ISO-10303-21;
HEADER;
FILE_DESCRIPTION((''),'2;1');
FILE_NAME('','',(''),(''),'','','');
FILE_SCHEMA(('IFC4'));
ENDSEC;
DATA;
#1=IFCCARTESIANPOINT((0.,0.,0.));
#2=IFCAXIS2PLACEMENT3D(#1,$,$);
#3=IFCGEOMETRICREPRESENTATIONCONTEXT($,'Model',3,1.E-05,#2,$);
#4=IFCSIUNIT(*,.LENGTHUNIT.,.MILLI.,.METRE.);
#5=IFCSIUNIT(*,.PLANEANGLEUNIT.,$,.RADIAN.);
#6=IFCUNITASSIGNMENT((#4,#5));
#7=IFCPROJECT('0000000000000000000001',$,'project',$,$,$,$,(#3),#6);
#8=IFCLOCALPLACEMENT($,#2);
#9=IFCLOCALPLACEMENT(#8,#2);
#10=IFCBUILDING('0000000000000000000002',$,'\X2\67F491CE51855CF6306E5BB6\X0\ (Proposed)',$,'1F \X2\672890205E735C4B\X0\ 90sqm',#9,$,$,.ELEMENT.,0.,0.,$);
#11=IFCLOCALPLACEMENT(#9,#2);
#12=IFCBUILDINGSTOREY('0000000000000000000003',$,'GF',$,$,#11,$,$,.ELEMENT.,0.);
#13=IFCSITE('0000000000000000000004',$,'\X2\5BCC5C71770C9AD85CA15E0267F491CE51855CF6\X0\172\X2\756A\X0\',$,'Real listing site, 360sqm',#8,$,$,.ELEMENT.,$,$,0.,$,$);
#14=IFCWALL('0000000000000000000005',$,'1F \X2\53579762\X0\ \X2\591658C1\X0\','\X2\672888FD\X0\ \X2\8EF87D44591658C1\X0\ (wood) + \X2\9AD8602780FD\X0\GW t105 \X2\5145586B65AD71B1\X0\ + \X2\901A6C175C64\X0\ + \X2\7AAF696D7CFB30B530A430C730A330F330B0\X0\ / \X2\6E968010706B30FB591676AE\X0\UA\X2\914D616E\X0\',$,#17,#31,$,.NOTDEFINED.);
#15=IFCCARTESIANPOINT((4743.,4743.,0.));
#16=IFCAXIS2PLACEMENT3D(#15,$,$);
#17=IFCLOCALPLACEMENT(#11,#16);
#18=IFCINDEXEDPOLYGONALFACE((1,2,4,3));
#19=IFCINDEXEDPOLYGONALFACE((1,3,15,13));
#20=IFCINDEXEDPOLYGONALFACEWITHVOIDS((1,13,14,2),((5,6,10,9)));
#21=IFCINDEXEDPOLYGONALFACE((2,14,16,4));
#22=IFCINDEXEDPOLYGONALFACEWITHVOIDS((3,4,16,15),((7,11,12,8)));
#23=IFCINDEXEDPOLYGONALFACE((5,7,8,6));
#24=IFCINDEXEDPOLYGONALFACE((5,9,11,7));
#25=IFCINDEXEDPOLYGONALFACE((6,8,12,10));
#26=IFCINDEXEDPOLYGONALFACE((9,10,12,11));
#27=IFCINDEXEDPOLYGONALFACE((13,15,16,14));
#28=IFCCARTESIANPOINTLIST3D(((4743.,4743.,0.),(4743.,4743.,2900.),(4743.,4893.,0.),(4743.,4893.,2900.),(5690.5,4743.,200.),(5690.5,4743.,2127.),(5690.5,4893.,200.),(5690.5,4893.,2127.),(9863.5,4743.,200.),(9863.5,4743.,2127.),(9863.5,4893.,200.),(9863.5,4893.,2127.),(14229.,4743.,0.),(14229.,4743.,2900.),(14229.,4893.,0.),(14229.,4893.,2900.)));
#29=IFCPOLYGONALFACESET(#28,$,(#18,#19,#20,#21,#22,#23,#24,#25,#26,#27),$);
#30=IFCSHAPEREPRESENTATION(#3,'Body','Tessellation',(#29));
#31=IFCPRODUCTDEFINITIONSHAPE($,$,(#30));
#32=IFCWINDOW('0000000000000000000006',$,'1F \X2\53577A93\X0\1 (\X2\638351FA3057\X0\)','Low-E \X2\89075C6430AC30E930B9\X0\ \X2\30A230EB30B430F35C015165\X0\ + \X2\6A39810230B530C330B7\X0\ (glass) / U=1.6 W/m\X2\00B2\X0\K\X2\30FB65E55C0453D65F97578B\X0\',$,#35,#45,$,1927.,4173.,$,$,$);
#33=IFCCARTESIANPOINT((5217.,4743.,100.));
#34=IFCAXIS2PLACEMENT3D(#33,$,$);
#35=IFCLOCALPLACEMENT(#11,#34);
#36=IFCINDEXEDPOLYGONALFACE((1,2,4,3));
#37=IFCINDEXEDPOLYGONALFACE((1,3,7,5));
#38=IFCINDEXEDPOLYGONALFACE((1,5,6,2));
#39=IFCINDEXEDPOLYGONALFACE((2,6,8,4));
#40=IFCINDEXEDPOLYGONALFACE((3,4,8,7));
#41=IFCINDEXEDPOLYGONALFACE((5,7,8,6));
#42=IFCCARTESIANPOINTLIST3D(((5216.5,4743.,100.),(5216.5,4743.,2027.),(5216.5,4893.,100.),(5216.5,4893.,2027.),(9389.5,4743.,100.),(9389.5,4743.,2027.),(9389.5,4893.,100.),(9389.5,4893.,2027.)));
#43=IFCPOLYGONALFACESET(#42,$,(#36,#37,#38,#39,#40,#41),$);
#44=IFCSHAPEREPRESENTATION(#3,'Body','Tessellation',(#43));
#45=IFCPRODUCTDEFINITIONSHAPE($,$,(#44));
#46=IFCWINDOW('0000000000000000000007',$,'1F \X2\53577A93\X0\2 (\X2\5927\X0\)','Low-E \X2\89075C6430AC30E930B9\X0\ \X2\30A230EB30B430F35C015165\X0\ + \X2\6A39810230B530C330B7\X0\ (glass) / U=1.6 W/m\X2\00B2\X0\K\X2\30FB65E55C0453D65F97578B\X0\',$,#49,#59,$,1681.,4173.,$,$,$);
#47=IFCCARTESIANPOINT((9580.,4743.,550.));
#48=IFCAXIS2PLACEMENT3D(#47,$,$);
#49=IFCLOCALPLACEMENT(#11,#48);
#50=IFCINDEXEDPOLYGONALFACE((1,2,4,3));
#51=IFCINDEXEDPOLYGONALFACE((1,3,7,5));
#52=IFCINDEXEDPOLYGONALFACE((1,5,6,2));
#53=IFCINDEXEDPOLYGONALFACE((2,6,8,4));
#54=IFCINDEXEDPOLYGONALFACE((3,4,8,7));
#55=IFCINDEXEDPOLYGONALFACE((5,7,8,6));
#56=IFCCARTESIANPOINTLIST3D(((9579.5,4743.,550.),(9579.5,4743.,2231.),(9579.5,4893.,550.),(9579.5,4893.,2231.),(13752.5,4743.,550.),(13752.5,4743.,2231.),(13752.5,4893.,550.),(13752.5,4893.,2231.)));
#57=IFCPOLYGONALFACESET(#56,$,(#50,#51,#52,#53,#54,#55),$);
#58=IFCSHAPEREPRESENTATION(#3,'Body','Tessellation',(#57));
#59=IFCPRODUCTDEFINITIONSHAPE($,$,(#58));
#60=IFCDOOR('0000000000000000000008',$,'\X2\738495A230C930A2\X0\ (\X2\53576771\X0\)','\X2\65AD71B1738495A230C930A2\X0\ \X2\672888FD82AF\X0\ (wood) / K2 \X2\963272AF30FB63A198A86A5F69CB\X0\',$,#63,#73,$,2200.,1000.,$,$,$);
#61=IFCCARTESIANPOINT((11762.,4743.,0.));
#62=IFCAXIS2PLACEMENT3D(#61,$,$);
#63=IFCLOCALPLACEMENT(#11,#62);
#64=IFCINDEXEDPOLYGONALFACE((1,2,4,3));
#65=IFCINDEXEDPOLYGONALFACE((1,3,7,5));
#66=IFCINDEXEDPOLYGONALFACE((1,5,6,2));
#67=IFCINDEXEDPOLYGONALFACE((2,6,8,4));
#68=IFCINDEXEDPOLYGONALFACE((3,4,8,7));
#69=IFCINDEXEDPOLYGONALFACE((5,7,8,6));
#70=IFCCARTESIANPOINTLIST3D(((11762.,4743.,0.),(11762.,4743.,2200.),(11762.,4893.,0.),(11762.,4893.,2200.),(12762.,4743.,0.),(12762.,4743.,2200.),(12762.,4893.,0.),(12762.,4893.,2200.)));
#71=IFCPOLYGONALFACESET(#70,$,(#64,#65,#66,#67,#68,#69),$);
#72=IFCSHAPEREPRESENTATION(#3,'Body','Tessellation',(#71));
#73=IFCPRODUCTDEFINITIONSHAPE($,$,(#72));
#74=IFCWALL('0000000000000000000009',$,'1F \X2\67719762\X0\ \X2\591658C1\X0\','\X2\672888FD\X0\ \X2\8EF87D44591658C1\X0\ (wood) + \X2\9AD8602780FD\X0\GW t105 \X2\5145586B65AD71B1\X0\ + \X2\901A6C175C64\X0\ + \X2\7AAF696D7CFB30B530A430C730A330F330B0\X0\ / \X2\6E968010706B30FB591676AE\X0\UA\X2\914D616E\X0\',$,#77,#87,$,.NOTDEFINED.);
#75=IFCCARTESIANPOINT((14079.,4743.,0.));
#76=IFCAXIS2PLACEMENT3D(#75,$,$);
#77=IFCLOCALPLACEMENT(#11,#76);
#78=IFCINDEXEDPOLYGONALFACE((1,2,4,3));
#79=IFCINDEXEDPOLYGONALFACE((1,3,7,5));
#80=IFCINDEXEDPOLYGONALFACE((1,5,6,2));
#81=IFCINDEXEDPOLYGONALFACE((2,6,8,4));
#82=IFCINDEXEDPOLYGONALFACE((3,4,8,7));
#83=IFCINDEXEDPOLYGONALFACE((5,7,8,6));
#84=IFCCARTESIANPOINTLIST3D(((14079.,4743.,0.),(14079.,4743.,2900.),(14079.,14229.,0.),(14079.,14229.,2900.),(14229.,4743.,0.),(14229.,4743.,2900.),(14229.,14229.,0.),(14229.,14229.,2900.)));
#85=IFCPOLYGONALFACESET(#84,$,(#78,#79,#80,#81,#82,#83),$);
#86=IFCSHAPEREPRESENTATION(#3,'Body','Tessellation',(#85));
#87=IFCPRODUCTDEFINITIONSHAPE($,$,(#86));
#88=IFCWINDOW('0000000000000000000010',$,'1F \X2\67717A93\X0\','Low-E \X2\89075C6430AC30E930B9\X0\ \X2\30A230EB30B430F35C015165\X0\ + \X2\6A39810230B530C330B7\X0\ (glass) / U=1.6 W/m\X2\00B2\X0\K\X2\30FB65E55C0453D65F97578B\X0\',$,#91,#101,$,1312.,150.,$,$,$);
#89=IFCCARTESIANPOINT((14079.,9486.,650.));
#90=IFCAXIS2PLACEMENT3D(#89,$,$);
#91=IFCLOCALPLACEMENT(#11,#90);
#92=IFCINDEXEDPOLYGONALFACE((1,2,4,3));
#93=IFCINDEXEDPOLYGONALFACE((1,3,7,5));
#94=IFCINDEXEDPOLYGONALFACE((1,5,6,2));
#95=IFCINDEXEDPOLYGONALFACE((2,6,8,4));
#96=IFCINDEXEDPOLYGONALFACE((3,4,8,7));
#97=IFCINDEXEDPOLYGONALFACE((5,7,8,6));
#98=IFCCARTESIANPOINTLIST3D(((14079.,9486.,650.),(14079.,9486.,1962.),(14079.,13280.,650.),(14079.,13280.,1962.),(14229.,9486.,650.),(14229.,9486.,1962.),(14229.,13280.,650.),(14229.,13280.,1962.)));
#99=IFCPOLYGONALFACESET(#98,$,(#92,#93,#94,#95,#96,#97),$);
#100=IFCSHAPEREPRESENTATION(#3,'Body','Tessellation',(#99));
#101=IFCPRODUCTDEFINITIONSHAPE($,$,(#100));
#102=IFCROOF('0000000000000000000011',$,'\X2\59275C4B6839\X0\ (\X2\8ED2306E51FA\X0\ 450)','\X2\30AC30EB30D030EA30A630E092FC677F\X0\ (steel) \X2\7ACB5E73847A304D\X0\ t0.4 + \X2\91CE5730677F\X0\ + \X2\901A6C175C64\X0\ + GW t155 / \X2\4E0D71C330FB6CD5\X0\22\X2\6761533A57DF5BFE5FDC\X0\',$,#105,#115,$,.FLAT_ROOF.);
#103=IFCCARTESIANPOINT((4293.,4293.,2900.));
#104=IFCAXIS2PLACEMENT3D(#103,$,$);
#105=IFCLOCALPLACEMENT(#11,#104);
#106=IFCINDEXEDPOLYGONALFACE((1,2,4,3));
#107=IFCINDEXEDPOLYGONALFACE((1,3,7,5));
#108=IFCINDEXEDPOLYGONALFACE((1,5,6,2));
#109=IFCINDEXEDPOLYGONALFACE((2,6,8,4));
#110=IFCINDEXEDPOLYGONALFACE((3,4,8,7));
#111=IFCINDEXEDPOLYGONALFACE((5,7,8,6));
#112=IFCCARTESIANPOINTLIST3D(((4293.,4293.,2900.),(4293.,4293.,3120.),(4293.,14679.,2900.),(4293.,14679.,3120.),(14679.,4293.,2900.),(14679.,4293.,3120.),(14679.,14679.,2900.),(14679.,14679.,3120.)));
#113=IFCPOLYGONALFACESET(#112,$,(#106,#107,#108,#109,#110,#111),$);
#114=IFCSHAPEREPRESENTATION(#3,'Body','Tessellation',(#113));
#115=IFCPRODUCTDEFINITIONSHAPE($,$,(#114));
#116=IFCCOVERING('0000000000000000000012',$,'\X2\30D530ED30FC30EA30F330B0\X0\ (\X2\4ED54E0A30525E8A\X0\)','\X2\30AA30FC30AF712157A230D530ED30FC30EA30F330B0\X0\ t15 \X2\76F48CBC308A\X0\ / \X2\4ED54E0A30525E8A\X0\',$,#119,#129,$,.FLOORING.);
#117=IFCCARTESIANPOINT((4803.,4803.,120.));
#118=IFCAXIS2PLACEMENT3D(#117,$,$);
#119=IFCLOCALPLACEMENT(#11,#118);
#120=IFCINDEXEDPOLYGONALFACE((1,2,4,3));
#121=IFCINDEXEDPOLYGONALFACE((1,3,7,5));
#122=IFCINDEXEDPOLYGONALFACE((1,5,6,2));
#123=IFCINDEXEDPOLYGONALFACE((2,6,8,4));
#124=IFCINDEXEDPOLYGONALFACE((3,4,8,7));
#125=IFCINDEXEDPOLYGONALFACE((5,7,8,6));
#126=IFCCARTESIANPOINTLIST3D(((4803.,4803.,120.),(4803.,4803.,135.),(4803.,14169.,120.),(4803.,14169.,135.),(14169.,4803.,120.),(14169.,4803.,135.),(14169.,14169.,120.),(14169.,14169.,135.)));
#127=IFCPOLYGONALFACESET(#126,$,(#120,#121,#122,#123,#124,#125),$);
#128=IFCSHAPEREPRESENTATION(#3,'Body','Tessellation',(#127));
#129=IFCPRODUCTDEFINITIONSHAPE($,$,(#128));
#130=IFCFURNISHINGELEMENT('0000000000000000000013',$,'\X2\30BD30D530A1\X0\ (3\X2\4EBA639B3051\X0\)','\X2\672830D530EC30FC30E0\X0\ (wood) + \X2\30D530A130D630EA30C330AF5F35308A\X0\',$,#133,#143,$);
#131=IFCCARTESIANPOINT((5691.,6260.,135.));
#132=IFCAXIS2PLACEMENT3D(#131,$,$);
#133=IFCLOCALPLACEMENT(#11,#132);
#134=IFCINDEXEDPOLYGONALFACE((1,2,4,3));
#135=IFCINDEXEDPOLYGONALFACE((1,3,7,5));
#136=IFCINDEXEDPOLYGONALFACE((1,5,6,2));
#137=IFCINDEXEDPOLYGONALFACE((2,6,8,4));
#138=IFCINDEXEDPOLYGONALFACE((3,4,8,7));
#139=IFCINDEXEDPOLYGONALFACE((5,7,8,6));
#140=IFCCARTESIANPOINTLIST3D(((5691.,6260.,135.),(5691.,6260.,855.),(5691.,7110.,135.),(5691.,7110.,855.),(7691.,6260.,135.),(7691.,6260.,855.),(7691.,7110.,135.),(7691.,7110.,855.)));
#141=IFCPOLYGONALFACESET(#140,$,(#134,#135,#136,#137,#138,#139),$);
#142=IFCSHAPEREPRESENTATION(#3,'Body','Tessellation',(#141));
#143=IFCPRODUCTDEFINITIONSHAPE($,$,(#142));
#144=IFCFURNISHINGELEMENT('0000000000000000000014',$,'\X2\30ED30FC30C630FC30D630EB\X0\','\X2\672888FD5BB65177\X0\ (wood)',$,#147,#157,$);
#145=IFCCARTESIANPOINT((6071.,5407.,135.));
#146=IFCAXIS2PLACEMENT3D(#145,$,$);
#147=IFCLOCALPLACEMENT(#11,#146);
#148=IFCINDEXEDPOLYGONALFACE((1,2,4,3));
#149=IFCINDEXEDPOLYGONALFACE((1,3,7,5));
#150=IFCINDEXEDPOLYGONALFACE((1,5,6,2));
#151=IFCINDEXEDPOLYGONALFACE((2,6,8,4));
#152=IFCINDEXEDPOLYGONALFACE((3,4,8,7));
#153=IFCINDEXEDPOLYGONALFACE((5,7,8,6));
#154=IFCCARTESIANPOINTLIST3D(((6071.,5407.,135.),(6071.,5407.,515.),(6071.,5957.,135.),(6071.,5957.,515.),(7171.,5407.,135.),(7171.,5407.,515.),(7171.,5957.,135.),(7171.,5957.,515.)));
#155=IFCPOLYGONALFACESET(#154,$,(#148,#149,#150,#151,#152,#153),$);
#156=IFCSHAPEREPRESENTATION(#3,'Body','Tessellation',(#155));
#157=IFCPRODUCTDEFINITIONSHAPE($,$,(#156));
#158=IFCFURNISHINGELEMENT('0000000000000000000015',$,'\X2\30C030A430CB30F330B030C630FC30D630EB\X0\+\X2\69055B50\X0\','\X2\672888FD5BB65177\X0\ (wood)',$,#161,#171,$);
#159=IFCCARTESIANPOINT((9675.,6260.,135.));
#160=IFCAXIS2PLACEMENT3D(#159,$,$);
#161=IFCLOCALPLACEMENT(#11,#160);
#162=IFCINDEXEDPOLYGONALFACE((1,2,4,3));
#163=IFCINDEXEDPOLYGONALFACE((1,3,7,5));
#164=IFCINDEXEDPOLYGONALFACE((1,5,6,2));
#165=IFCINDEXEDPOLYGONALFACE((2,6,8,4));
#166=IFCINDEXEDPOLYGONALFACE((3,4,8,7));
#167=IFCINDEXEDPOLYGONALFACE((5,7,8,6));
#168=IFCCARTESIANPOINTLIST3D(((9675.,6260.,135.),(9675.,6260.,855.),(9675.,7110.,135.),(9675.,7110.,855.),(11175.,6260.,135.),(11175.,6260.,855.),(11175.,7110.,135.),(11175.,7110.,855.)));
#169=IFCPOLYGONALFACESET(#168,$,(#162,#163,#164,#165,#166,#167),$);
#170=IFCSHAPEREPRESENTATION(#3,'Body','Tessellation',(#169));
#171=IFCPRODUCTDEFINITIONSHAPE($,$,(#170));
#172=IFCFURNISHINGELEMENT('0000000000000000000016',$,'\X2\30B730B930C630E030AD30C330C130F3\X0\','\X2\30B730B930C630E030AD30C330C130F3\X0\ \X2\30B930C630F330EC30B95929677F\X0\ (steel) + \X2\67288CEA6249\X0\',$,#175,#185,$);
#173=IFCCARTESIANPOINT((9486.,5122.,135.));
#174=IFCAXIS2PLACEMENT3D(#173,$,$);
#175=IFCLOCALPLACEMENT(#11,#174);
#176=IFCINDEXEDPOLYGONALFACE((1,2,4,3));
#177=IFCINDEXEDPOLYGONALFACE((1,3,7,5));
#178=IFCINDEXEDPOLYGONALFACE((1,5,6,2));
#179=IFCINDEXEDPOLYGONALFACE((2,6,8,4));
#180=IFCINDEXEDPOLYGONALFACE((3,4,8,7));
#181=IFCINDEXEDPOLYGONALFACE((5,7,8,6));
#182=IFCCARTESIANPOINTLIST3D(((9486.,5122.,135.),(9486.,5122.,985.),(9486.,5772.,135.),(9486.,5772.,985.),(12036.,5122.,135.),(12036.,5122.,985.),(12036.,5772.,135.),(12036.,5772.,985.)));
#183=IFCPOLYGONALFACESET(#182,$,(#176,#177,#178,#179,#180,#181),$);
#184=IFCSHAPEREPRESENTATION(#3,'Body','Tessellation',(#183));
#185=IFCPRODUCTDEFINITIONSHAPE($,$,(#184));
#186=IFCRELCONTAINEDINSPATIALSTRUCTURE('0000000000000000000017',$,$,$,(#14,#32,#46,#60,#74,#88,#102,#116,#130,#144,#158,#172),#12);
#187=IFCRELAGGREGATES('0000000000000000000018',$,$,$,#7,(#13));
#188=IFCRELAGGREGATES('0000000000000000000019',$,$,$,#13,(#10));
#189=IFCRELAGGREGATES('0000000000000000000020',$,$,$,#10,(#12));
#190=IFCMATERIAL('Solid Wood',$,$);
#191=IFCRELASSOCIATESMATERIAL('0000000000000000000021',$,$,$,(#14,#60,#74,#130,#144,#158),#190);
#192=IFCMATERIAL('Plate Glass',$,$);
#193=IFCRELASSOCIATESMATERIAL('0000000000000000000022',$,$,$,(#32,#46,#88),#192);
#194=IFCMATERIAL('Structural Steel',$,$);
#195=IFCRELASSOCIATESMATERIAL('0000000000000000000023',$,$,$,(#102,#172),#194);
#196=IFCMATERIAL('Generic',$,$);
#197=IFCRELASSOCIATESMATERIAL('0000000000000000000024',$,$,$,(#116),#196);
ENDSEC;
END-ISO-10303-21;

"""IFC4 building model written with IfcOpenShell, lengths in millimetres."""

from ifc_helpers import new_model, si_unit, frame, frame_2d, origin, place, context, project, spatial, rectangle, extrude, material, element, fill, save


model = new_model("IFC4")

# Units and contexts
model_context = context("Model", 3, precision=1e-05, world=origin())
ifc_project = project(units=[si_unit("LENGTHUNIT", "METRE", prefix="MILLI"), si_unit("PLANEANGLEUNIT", "RADIAN")], contexts=[model_context])

# Site, building, storey
site_placement = place(None, origin())
site = spatial("IfcSite", under=ifc_project, at=site_placement, Name="富山県高岡市柴野内島172番", ObjectType="Real listing site, 360sqm", CompositionType="ELEMENT", RefElevation=0.0)
building_placement = place(site_placement, origin())
building = spatial("IfcBuilding", under=site, at=building_placement, Name="柴野内島の家 (Proposed)", ObjectType="1F 木造平屋 90sqm", CompositionType="ELEMENT", ElevationOfRefHeight=0.0, ElevationOfTerrain=0.0)
storey_placement = place(building_placement, origin())
storey = spatial("IfcBuildingStorey", under=building, at=storey_placement, Name="GF", CompositionType="ELEMENT", Elevation=0.0)

# Shared definitions
ifc_material_1 = material(Name="Solid Wood")

# Wall, openings, windows, door
wall_1_placement = place(storey_placement, frame((4743.0, 4743.0, 0.0)))
wall_1 = element("IfcWall", 1, at=wall_1_placement, inside=storey, material=ifc_material_1, Name="1F 南面 外壁", Description="木製 軸組外壁 (wood) + 高性能GW t105 充填断熱 + 通気層 + 窯業系サイディング / 準耐火・外皮UA配慮", PredefinedType="NOTDEFINED", context=model_context, shape_type="SweptSolid", body=[
    extrude(rectangle(XDim=9486.0, YDim=150.0, at=frame_2d((4743.0, 75.0))), frame((4743.0, 4743.0, 0.0)), (0.0, 0.0, 1.0), 2900.0),
])
opening_1_placement = place(storey_placement, frame((5217.0, 4743.0, 100.0)))
opening_1 = element("IfcOpeningElement", 2, at=opening_1_placement, cuts=wall_1, PredefinedType="NOTDEFINED", context=model_context, shape_type="SweptSolid", body=[
    extrude(rectangle(XDim=4173.0, YDim=150.0, at=frame_2d((2086.0, 75.0))), frame((5217.0, 4743.0, 100.0)), (0.0, 0.0, 1.0), 1927.0),
])
opening_2_placement = place(storey_placement, frame((9580.0, 4743.0, 550.0)))
opening_2 = element("IfcOpeningElement", 3, at=opening_2_placement, cuts=wall_1, PredefinedType="NOTDEFINED", context=model_context, shape_type="SweptSolid", body=[
    extrude(rectangle(XDim=4173.0, YDim=150.0, at=frame_2d((2086.0, 75.0))), frame((9580.0, 4743.0, 550.0)), (0.0, 0.0, 1.0), 1681.0),
])
opening_3_placement = place(storey_placement, frame((11762.0, 4743.0, 0.0)))
opening_3 = element("IfcOpeningElement", 4, at=opening_3_placement, cuts=wall_1, PredefinedType="NOTDEFINED", context=model_context, shape_type="SweptSolid", body=[
    extrude(rectangle(XDim=1000.0, YDim=150.0, at=frame_2d((500.0, 75.0))), frame((11762.0, 4743.0, 0.0)), (0.0, 0.0, 1.0), 2200.0),
])
ifc_material_2 = material(Name="Plate Glass")
window_1_placement = place(storey_placement, frame((5217.0, 4743.0, 100.0)))
window_1 = element("IfcWindow", 5, at=window_1_placement, inside=storey, material=ifc_material_2, Name="1F 南窓1 (掃出し)", Description="Low-E 複層ガラス アルゴン封入 + 樹脂サッシ (glass) / U=1.6 W/m²K・日射取得型", OverallHeight=1927.0, OverallWidth=4173.0, context=model_context, shape_type="SweptSolid", body=[
    extrude(rectangle(XDim=4173.0, YDim=150.0, at=frame_2d((2086.0, 75.0))), frame((5217.0, 4743.0, 100.0)), (0.0, 0.0, 1.0), 1927.0),
])
fill(opening_1, window_1)
window_2_placement = place(storey_placement, frame((9580.0, 4743.0, 550.0)))
window_2 = element("IfcWindow", 6, at=window_2_placement, inside=storey, material=ifc_material_2, Name="1F 南窓2 (大)", Description="Low-E 複層ガラス アルゴン封入 + 樹脂サッシ (glass) / U=1.6 W/m²K・日射取得型", OverallHeight=1681.0, OverallWidth=4173.0, context=model_context, shape_type="SweptSolid", body=[
    extrude(rectangle(XDim=4173.0, YDim=150.0, at=frame_2d((2086.0, 75.0))), frame((9580.0, 4743.0, 550.0)), (0.0, 0.0, 1.0), 1681.0),
])
fill(opening_2, window_2)
door_placement = place(storey_placement, frame((11762.0, 4743.0, 0.0)))
door = element("IfcDoor", 7, at=door_placement, inside=storey, material=ifc_material_1, Name="玄関ドア (南東)", Description="断熱玄関ドア 木製芯 (wood) / K2 防犯・採風機構", OverallHeight=2200.0, OverallWidth=1000.0, context=model_context, shape_type="SweptSolid", body=[
    extrude(rectangle(XDim=1000.0, YDim=150.0, at=frame_2d((500.0, 75.0))), frame((11762.0, 4743.0, 0.0)), (0.0, 0.0, 1.0), 2200.0),
])
fill(opening_3, door)

# Wall, opening, window
wall_2_placement = place(storey_placement, frame((14079.0, 4743.0, 0.0)))
wall_2 = element("IfcWall", 8, at=wall_2_placement, inside=storey, material=ifc_material_1, Name="1F 東面 外壁", Description="木製 軸組外壁 (wood) + 高性能GW t105 充填断熱 + 通気層 + 窯業系サイディング / 準耐火・外皮UA配慮", PredefinedType="NOTDEFINED", context=model_context, shape_type="SweptSolid", body=[
    extrude(rectangle(XDim=150.0, YDim=9486.0, at=frame_2d((75.0, 4743.0))), frame((14079.0, 4743.0, 0.0)), (0.0, 0.0, 1.0), 2900.0),
])
opening_4_placement = place(storey_placement, frame((14079.0, 9486.0, 650.0)))
opening_4 = element("IfcOpeningElement", 9, at=opening_4_placement, cuts=wall_2, PredefinedType="NOTDEFINED", context=model_context, shape_type="SweptSolid", body=[
    extrude(rectangle(XDim=150.0, YDim=3794.0, at=frame_2d((75.0, 1897.0))), frame((14079.0, 9486.0, 650.0)), (0.0, 0.0, 1.0), 1312.0),
])
window_3_placement = place(storey_placement, frame((14079.0, 9486.0, 650.0)))
window_3 = element("IfcWindow", 10, at=window_3_placement, inside=storey, material=ifc_material_2, Name="1F 東窓", Description="Low-E 複層ガラス アルゴン封入 + 樹脂サッシ (glass) / U=1.6 W/m²K・日射取得型", OverallHeight=1312.0, OverallWidth=150.0, context=model_context, shape_type="SweptSolid", body=[
    extrude(rectangle(XDim=150.0, YDim=3794.0, at=frame_2d((75.0, 1897.0))), frame((14079.0, 9486.0, 650.0)), (0.0, 0.0, 1.0), 1312.0),
])
fill(opening_4, window_3)

# Roof
ifc_material_3 = material(Name="Structural Steel")
roof_placement = place(storey_placement, frame((4293.0, 4293.0, 2900.0)))
element("IfcRoof", 11, at=roof_placement, inside=storey, material=ifc_material_3, Name="大屋根 (軒の出 450)", Description="ガルバリウム鋼板 (steel) 立平葺き t0.4 + 野地板 + 通気層 + GW t155 / 不燃・法22条区域対応", PredefinedType="FLAT_ROOF", context=model_context, shape_type="SweptSolid", body=[
    extrude(rectangle(XDim=10386.0, YDim=10386.0, at=frame_2d((5193.0, 5193.0))), frame((4293.0, 4293.0, 2900.0)), (0.0, 0.0, 1.0), 220.0),
])

# Covering
ifc_material_4 = material(Name="Generic")
covering_placement = place(storey_placement, frame((4803.0, 4803.0, 120.0)))
element("IfcCovering", 12, at=covering_placement, inside=storey, material=ifc_material_4, Name="フローリング (仕上げ床)", Description="オーク無垢フローリング t15 直貼り / 仕上げ床", PredefinedType="FLOORING", context=model_context, shape_type="SweptSolid", body=[
    extrude(rectangle(XDim=9366.0, YDim=9366.0, at=frame_2d((4683.0, 4683.0))), frame((4803.0, 4803.0, 120.0)), (0.0, 0.0, 1.0), 15.0),
])

# Furnishing elements
furnishing_1_placement = place(storey_placement, frame((5691.0, 6260.0, 135.0)))
element("IfcFurnishingElement", 13, at=furnishing_1_placement, inside=storey, material=ifc_material_1, Name="ソファ (3人掛け)", Description="木フレーム (wood) + ファブリック張り", context=model_context, shape_type="SweptSolid", body=[
    extrude(rectangle(XDim=2000.0, YDim=850.0, at=frame_2d((1000.0, 425.0))), frame((5691.0, 6260.0, 135.0)), (0.0, 0.0, 1.0), 720.0),
])
furnishing_2_placement = place(storey_placement, frame((6071.0, 5407.0, 135.0)))
element("IfcFurnishingElement", 14, at=furnishing_2_placement, inside=storey, material=ifc_material_1, Name="ローテーブル", Description="木製家具 (wood)", context=model_context, shape_type="SweptSolid", body=[
    extrude(rectangle(XDim=1100.0, YDim=550.0, at=frame_2d((550.0, 275.0))), frame((6071.0, 5407.0, 135.0)), (0.0, 0.0, 1.0), 380.0),
])
furnishing_3_placement = place(storey_placement, frame((9675.0, 6260.0, 135.0)))
element("IfcFurnishingElement", 15, at=furnishing_3_placement, inside=storey, material=ifc_material_1, Name="ダイニングテーブル+椅子", Description="木製家具 (wood)", context=model_context, shape_type="SweptSolid", body=[
    extrude(rectangle(XDim=1500.0, YDim=850.0, at=frame_2d((750.0, 425.0))), frame((9675.0, 6260.0, 135.0)), (0.0, 0.0, 1.0), 720.0),
])
furnishing_4_placement = place(storey_placement, frame((9486.0, 5122.0, 135.0)))
element("IfcFurnishingElement", 16, at=furnishing_4_placement, inside=storey, material=ifc_material_3, Name="システムキッチン", Description="システムキッチン ステンレス天板 (steel) + 木質扉", context=model_context, shape_type="SweptSolid", body=[
    extrude(rectangle(XDim=2550.0, YDim=650.0, at=frame_2d((1275.0, 325.0))), frame((9486.0, 5122.0, 135.0)), (0.0, 0.0, 1.0), 850.0),
])

save(model, "model.ifc")
